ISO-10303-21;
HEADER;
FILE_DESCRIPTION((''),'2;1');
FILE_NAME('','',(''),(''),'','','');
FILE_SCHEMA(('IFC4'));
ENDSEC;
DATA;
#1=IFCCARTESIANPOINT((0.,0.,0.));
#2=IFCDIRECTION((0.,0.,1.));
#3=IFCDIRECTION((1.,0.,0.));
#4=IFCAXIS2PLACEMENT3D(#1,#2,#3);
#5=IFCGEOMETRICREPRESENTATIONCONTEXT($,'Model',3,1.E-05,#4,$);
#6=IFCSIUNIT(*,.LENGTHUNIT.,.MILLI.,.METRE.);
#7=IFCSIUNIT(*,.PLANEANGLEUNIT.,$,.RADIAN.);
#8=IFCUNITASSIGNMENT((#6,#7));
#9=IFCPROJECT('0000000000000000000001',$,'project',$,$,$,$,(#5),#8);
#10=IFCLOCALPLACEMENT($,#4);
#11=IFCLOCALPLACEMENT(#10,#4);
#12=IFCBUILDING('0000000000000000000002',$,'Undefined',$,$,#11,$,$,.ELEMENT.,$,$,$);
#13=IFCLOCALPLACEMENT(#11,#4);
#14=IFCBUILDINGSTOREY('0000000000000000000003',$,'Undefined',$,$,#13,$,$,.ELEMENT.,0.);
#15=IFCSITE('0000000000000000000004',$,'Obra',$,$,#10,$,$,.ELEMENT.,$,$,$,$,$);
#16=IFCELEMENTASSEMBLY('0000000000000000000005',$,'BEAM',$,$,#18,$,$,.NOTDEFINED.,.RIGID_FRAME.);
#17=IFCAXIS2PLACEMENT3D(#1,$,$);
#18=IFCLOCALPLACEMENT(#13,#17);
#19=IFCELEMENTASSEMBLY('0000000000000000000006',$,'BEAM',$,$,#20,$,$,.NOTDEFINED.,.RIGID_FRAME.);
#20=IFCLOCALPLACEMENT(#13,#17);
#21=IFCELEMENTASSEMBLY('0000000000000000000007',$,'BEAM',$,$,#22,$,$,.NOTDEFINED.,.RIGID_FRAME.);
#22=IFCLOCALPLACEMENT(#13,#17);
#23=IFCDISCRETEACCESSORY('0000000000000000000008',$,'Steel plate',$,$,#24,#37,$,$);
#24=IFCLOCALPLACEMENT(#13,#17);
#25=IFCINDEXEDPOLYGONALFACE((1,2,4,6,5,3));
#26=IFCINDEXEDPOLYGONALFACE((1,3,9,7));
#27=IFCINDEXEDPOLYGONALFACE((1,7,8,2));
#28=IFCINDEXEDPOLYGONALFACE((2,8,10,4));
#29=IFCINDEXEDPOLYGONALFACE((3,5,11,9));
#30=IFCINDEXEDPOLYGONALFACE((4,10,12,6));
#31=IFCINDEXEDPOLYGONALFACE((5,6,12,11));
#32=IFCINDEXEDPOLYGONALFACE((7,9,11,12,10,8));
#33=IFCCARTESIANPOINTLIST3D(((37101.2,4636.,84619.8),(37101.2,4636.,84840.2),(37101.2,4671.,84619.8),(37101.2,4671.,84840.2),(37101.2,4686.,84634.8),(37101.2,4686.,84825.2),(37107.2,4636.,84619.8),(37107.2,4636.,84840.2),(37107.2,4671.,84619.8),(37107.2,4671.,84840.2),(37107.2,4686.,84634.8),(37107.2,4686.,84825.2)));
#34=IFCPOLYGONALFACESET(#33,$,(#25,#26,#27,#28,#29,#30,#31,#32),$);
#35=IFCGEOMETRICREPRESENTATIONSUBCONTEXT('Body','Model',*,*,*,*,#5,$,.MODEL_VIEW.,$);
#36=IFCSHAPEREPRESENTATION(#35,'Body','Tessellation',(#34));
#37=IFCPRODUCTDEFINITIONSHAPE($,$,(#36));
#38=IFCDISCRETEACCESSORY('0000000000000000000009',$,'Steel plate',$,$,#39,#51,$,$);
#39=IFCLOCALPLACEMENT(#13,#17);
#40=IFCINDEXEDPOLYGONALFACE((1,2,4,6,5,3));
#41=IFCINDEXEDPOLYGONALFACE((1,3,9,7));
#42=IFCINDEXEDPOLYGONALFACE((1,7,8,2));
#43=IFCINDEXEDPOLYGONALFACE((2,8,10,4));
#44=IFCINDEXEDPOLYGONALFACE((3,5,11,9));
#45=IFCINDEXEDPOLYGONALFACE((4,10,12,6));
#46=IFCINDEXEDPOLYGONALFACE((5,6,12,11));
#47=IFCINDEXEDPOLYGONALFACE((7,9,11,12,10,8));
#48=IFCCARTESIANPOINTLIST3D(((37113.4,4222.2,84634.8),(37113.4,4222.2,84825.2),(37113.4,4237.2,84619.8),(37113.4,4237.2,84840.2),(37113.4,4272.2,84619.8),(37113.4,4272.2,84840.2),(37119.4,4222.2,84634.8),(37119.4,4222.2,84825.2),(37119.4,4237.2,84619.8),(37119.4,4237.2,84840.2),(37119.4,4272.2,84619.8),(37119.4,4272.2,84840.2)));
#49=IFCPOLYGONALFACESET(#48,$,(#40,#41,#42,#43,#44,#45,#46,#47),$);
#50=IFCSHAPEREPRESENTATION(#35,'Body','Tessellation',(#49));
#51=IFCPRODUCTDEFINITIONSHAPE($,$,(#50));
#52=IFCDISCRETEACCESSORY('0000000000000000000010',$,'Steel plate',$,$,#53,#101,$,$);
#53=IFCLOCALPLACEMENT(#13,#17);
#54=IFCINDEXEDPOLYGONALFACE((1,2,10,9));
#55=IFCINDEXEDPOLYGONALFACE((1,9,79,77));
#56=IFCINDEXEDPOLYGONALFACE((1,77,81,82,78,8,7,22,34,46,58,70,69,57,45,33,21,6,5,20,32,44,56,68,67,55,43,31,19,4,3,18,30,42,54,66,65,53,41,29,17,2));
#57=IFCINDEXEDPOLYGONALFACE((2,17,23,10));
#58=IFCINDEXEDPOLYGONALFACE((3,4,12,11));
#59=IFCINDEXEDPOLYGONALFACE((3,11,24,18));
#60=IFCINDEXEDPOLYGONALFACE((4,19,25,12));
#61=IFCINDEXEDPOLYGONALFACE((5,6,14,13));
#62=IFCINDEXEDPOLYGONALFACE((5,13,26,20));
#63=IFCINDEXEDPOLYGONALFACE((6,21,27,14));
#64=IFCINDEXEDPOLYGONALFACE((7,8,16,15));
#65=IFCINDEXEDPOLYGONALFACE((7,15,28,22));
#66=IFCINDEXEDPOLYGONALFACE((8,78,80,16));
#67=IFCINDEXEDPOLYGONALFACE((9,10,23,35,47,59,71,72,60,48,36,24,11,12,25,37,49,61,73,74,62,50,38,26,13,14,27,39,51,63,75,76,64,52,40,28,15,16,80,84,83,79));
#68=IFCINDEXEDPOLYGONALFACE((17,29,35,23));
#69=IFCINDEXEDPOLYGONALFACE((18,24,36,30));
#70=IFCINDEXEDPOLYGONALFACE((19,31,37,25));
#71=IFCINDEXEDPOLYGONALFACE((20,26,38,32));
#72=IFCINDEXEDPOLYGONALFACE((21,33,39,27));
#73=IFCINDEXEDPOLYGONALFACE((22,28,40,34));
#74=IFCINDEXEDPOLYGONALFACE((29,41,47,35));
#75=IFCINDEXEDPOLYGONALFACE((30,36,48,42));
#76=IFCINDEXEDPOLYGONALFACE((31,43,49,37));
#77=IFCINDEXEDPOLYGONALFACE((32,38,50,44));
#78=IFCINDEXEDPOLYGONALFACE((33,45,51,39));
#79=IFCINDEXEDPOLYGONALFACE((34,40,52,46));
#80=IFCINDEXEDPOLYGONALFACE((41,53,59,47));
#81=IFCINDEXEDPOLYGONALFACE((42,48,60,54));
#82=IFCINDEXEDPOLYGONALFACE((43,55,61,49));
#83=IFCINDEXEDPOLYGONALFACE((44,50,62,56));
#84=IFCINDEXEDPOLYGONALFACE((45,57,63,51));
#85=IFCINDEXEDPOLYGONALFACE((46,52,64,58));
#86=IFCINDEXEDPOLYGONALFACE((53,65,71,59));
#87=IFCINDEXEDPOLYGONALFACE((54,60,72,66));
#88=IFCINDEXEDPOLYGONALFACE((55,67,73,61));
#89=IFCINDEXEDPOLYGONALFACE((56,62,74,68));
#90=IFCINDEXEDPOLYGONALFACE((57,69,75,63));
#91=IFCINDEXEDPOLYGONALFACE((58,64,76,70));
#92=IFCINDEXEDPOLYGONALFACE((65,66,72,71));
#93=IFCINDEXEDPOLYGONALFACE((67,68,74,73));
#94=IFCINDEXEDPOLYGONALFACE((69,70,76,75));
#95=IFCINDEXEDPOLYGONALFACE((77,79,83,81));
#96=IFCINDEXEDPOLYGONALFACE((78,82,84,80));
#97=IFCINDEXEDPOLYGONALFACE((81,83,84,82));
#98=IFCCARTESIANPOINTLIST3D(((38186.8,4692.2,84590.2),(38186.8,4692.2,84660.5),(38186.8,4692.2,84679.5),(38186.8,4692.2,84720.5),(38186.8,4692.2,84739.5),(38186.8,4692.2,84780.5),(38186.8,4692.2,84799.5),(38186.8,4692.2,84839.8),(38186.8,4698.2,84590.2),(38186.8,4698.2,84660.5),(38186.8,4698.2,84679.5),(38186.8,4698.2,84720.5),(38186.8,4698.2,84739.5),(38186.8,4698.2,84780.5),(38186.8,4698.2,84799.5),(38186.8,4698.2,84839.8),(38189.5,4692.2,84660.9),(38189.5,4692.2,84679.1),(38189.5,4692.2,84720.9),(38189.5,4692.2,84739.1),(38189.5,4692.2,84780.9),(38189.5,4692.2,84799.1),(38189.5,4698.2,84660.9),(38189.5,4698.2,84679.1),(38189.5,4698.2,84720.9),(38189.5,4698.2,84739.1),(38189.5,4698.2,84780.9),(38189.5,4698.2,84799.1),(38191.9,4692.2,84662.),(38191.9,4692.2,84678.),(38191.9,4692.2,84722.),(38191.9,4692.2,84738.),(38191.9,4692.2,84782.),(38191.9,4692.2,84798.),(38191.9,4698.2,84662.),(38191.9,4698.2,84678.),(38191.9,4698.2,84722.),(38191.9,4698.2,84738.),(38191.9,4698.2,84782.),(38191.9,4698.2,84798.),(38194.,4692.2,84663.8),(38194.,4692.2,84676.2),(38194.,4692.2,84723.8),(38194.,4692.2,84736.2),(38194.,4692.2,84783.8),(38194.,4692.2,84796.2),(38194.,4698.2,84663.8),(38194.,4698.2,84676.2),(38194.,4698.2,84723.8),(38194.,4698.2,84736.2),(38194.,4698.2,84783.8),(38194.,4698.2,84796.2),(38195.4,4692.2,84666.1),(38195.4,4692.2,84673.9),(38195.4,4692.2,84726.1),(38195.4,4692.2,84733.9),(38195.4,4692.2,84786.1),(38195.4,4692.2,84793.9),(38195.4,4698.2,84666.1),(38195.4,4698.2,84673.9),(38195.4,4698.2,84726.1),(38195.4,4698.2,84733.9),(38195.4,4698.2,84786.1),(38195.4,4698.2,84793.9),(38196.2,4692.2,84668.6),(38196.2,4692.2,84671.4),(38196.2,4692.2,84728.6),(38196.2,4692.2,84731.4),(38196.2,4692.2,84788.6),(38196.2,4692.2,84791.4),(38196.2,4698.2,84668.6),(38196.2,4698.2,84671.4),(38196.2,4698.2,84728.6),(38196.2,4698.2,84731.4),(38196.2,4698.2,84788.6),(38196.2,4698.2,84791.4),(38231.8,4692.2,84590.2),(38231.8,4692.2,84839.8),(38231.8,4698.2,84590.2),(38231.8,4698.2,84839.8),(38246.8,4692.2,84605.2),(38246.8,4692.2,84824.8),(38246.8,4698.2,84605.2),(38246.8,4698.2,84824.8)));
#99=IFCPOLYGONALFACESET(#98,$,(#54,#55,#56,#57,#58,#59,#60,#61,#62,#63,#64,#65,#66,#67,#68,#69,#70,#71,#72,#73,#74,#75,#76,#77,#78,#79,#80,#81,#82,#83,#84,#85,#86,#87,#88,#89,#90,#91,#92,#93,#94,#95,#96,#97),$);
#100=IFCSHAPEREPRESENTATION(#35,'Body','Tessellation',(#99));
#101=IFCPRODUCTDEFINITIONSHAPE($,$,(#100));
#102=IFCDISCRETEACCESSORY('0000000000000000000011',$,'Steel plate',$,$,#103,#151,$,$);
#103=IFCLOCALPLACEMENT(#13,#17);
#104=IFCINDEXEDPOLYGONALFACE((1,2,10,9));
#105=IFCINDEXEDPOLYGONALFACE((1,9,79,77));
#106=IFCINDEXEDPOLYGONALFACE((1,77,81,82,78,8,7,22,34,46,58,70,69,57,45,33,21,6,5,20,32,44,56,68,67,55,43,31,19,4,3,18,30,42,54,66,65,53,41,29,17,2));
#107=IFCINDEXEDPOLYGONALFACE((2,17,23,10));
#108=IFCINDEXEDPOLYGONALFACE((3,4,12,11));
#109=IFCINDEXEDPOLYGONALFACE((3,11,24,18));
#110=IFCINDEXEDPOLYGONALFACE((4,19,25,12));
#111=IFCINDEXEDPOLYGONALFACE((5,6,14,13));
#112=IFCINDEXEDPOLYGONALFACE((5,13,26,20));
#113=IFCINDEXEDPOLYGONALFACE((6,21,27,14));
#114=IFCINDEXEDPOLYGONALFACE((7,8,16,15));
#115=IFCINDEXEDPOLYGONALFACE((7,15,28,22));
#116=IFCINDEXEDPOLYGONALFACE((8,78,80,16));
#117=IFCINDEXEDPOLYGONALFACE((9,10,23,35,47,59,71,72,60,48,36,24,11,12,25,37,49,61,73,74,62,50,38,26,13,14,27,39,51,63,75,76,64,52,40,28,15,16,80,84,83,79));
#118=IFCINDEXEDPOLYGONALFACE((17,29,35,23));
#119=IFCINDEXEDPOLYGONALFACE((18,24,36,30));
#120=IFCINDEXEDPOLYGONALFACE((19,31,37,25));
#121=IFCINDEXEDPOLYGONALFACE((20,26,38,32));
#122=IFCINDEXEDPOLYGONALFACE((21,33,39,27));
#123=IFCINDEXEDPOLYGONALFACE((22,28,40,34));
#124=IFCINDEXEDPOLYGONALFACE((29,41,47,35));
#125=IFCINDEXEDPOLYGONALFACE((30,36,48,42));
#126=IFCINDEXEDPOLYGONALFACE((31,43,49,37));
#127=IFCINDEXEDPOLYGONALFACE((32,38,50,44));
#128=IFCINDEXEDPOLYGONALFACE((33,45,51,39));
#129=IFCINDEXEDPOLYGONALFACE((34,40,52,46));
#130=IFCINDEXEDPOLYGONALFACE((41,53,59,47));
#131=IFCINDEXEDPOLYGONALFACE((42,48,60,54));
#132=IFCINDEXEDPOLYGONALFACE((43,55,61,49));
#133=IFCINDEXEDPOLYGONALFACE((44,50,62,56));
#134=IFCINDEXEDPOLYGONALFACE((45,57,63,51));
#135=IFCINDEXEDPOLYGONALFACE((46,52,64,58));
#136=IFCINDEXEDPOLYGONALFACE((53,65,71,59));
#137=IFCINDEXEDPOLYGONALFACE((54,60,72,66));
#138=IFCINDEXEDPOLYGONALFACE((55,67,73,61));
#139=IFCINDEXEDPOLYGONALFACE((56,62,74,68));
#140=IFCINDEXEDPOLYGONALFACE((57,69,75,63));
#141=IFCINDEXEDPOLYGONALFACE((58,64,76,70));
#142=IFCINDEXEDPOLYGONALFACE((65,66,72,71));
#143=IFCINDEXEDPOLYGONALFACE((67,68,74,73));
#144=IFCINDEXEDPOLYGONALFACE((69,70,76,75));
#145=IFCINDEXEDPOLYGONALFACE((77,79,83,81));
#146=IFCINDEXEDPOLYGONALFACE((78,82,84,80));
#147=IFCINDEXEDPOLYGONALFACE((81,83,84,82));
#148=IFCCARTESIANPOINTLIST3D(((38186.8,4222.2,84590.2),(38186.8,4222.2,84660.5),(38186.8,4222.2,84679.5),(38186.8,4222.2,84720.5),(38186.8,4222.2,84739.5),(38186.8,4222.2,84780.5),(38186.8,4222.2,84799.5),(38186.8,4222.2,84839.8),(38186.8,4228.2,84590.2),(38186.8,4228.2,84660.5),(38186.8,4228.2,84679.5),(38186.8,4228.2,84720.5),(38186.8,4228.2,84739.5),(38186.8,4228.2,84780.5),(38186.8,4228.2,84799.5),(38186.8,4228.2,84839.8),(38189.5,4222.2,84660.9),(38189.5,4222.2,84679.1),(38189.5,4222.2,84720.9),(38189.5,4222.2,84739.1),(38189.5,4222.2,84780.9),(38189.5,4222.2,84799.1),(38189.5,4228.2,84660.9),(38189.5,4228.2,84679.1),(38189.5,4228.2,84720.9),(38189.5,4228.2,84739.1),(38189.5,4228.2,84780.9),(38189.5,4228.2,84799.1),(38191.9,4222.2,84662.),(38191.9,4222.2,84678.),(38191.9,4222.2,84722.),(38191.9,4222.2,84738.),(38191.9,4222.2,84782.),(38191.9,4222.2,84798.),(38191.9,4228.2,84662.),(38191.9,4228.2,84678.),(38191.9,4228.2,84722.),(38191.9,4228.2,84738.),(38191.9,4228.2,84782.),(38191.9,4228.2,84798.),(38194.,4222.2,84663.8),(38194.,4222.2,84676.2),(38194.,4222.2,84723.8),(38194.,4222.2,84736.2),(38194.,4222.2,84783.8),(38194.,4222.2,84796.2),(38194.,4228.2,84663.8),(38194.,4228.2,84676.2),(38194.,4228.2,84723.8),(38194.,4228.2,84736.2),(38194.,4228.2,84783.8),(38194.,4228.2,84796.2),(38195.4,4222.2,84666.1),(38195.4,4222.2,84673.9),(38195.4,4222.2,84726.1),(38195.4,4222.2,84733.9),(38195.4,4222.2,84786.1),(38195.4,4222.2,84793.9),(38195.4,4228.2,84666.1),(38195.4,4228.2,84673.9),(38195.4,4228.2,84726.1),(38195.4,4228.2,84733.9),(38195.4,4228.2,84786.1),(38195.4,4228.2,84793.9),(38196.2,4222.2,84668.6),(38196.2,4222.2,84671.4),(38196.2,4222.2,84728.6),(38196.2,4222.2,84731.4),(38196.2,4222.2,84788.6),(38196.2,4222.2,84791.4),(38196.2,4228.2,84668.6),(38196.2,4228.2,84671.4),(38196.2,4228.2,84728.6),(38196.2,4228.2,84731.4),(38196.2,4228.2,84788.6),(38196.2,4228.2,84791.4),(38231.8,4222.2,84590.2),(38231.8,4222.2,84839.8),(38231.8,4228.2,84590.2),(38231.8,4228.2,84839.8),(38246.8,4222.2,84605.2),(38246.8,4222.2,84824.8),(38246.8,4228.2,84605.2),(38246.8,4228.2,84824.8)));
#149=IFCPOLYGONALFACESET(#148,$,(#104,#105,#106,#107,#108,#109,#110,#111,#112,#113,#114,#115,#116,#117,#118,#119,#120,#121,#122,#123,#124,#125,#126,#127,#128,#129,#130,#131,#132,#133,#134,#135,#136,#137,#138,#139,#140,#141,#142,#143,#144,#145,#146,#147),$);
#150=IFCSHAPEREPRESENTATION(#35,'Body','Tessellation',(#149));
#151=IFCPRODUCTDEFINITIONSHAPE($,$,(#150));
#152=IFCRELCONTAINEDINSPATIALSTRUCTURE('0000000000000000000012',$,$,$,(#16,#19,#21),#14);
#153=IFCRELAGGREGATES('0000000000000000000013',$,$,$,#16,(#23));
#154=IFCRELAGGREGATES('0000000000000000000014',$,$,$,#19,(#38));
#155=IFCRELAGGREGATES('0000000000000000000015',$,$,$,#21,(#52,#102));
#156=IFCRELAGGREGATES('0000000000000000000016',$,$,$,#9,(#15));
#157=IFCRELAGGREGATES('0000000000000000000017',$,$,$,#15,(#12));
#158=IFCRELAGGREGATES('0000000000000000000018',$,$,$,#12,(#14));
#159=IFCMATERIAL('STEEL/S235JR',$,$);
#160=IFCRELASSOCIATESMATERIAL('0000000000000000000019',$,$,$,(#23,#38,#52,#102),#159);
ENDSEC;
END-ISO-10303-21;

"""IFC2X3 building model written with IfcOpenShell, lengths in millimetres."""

from ifc_helpers import new_model, si_unit, frame, origin_with_axes, origin_2d_with_axis, place, context, subcontext, project, spatial, polyline, circle, outline, extrude, source, transform, mapped, material, element, aggregate, save


model = new_model("IFC2X3")

# Units and contexts
model_context = context("Model", 3, precision=1e-05, world=origin_with_axes())
body_context = subcontext(model_context, "Body", "Model", "MODEL_VIEW")
ifc_project = project(units=[si_unit("LENGTHUNIT", "METRE", prefix="MILLI"), si_unit("PLANEANGLEUNIT", "RADIAN")], contexts=[model_context])

# Site, building, storey
site_placement = place(None, origin_with_axes())
site = spatial("IfcSite", under=ifc_project, at=site_placement, Name="Obra", CompositionType="ELEMENT")
building_placement = place(site_placement, origin_with_axes())
building = spatial("IfcBuilding", under=site, at=building_placement, Name="Undefined", CompositionType="ELEMENT")
storey_placement = place(building_placement, origin_with_axes())
storey = spatial("IfcBuildingStorey", under=building, at=storey_placement, Name="Undefined", CompositionType="ELEMENT", Elevation=0.0)

# Element assemblies
ifc_material = material(Name="STEEL/S235JR")
assembly_1_placement = place(storey_placement, origin_with_axes())
assembly_1 = element("IfcElementAssembly", 1, at=assembly_1_placement, inside=storey, Name="BEAM", AssemblyPlace="NOTDEFINED", PredefinedType="RIGID_FRAME")
assembly_2_placement = place(storey_placement, origin_with_axes())
assembly_2 = element("IfcElementAssembly", 2, at=assembly_2_placement, inside=storey, Name="BEAM", AssemblyPlace="NOTDEFINED", PredefinedType="RIGID_FRAME")
assembly_3_placement = place(storey_placement, origin_with_axes())
assembly_3 = element("IfcElementAssembly", 3, at=assembly_3_placement, inside=storey, Name="BEAM", AssemblyPlace="NOTDEFINED", PredefinedType="RIGID_FRAME")

# Discrete accessories
discrete_accessory_1_placement = place(assembly_1_placement, frame((37104.2, 4636.0, 84619.8), z_axis=(1.0, 0.0, 0.0), x_axis=(0.0, 1.0, 0.0)))
discrete_accessory_1 = element("IfcDiscreteAccessory", 4, at=discrete_accessory_1_placement, material=ifc_material, Name="Steel plate", context=body_context, shape_type="SweptSolid", body=[
    extrude(outline(polyline([(0.0, 0.0), (35.0, 0.0), (50.0, 15.0), (50.0, 205.4), (35.0, 220.4), (0.0, 220.4), (0.0, 0.0)])), frame((0.0, 0.0, -3.0), z_axis=(0.0, 0.0, 1.0), x_axis=(1.0, 0.0, 0.0)), (0.0, 0.0, 1.0), 6.0),
])
aggregate(assembly_1, [discrete_accessory_1])
discrete_accessory_2_placement = place(assembly_2_placement, frame((37116.4, 4272.2, 84619.8), z_axis=(-1.0, 0.0, 0.0), x_axis=(0.0, -1.0, 0.0)))
discrete_accessory_2 = element("IfcDiscreteAccessory", 5, at=discrete_accessory_2_placement, material=ifc_material, Name="Steel plate", context=body_context, shape_type="SweptSolid", body=[
    extrude(outline(polyline([(0.0, 0.0), (35.0, 0.0), (50.0, 15.0), (50.0, 205.4), (35.0, 220.4), (0.0, 220.4), (0.0, 0.0)])), frame((0.0, 0.0, -3.0), z_axis=(0.0, 0.0, 1.0), x_axis=(1.0, 0.0, 0.0)), (0.0, 0.0, 1.0), 6.0),
])
aggregate(assembly_2, [discrete_accessory_2])

# Discrete accessories, openings
discrete_accessory_3_placement = place(assembly_3_placement, frame((38186.8, 4695.2, 84590.2), z_axis=(0.0, -1.0, 0.0), x_axis=(1.0, 0.0, 0.0)))
discrete_accessory_3 = element("IfcDiscreteAccessory", 6, at=discrete_accessory_3_placement, material=ifc_material, Name="Steel plate", context=body_context, shape_type="SweptSolid", body=[
    extrude(outline(polyline([(0.0, 0.0), (45.0, 0.0), (60.0, 15.0), (60.0, 234.6), (45.0, 249.6), (0.0, 249.6), (0.0, 0.0)])), frame((0.0, 0.0, -3.0), z_axis=(0.0, 0.0, 1.0), x_axis=(1.0, 0.0, 0.0)), (0.0, 0.0, 1.0), 6.0),
])
shared_shape_1 = source(origin_with_axes(), body_context, "Body", "SweptSolid", [
    extrude(circle(Radius=9.5, at=origin_2d_with_axis()), frame((0.0, -9.2, 0.0), z_axis=(0.0, 1.0, 0.0), x_axis=(1.0, 0.0, 0.0)), (0.0, 0.0, 1.0), 6.2),
])
opening_1_placement = place(assembly_3_placement, frame((38236.8, 4689.1, 84850.0), z_axis=(-1.0, 0.0, 0.0), x_axis=(0.0, 0.0, -1.0)))
element("IfcOpeningElement", 7, at=opening_1_placement, cuts=discrete_accessory_3, ObjectType="Opening", context=body_context, shape_type="MappedRepresentation", body=[
    mapped(shared_shape_1, transform((60.0, 0.0, 50.0))),
    mapped(shared_shape_1, transform((120.0, 0.0, 50.0))),
    mapped(shared_shape_1, transform((180.0, 0.0, 50.0))),
])
discrete_accessory_4_placement = place(assembly_3_placement, frame((38186.8, 4225.2, 84590.2), z_axis=(0.0, -1.0, 0.0), x_axis=(1.0, 0.0, 0.0)))
discrete_accessory_4 = element("IfcDiscreteAccessory", 8, at=discrete_accessory_4_placement, material=ifc_material, Name="Steel plate", context=body_context, shape_type="SweptSolid", body=[
    extrude(outline(polyline([(0.0, 0.0), (45.0, 0.0), (60.0, 15.0), (60.0, 234.6), (45.0, 249.6), (0.0, 249.6), (0.0, 0.0)])), frame((0.0, 0.0, -3.0), z_axis=(0.0, 0.0, 1.0), x_axis=(1.0, 0.0, 0.0)), (0.0, 0.0, 1.0), 6.0),
])
opening_2_placement = place(assembly_3_placement, frame((38236.8, 4219.1, 84850.0), z_axis=(-1.0, 0.0, 0.0), x_axis=(0.0, 0.0, -1.0)))
element("IfcOpeningElement", 9, at=opening_2_placement, cuts=discrete_accessory_4, ObjectType="Opening", context=body_context, shape_type="MappedRepresentation", body=[
    mapped(shared_shape_1, transform((60.0, 0.0, 50.0))),
    mapped(shared_shape_1, transform((120.0, 0.0, 50.0))),
    mapped(shared_shape_1, transform((180.0, 0.0, 50.0))),
])
aggregate(assembly_3, [discrete_accessory_3, discrete_accessory_4])

save(model, "model.ifc")
